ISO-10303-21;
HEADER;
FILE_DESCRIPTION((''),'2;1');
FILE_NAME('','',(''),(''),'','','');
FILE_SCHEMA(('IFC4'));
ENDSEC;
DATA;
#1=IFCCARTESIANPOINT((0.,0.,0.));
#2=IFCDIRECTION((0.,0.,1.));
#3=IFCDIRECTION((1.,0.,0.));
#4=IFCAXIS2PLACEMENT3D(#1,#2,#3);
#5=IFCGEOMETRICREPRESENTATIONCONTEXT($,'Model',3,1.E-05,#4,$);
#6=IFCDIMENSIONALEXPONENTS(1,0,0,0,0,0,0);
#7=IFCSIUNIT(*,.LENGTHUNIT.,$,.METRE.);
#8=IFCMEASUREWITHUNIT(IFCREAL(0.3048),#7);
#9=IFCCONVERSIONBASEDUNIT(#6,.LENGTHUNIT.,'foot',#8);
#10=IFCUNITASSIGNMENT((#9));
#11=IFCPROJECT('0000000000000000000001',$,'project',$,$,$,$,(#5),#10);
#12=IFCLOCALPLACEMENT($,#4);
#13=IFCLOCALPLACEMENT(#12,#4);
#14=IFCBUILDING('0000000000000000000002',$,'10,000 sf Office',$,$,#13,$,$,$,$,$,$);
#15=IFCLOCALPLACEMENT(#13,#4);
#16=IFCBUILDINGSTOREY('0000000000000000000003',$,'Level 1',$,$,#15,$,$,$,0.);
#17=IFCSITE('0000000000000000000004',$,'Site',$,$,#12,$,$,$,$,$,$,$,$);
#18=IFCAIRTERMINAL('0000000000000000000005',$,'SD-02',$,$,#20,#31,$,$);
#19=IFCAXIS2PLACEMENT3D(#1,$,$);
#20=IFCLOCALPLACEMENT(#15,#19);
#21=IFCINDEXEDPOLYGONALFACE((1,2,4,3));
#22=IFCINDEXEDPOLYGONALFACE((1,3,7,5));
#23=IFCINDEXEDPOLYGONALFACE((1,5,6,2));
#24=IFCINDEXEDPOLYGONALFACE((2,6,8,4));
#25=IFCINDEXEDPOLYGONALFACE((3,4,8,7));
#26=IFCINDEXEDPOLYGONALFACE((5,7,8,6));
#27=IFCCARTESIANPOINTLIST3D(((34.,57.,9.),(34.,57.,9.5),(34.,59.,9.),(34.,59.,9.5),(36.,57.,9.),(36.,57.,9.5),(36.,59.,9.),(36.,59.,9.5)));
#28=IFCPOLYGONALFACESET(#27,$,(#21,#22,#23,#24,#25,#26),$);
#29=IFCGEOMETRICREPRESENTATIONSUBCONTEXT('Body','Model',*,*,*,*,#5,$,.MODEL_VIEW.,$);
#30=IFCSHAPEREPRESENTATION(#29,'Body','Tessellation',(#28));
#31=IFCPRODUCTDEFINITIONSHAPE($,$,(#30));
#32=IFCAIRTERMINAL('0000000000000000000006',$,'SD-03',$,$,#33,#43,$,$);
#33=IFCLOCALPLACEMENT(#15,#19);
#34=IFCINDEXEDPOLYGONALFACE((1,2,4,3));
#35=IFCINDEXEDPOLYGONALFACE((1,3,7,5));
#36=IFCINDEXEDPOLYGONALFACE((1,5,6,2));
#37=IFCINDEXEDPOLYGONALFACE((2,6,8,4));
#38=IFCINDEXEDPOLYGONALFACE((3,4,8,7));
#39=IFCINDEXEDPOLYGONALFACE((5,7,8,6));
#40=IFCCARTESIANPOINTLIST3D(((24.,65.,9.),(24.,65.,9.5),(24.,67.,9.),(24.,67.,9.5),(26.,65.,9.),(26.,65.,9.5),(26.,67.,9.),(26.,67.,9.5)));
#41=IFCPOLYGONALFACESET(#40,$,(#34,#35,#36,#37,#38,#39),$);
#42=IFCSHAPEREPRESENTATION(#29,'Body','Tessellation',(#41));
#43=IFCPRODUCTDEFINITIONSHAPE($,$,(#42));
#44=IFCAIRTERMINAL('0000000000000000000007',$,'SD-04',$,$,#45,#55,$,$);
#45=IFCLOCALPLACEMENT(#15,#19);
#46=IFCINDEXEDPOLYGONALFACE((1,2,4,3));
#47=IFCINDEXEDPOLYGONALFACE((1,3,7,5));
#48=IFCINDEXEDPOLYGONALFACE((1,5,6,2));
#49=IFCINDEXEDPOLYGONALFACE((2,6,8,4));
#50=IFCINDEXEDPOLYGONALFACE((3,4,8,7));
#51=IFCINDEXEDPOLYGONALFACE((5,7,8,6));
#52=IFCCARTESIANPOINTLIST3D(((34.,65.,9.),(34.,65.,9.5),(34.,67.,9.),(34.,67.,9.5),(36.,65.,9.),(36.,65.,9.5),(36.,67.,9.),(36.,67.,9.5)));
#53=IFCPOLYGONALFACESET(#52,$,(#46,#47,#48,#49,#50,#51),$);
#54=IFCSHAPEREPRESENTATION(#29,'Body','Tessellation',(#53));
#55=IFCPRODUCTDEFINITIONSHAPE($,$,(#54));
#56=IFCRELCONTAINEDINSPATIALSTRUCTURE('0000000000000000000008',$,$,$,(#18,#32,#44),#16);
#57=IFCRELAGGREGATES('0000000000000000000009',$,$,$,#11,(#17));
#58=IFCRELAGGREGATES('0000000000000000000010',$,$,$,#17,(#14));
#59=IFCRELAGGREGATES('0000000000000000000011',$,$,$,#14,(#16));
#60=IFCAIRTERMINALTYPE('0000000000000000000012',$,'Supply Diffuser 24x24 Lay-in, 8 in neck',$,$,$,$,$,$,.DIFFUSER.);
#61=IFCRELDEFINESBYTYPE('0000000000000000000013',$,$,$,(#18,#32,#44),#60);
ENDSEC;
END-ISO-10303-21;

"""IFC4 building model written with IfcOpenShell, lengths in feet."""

from ifc_helpers import new_model, entity, si_unit, converted_unit, frame, origin_with_axes, place, context, subcontext, project, spatial, rectangle, extrude, type_object, element, save


model = new_model("IFC4")

# Units and contexts
model_context = context("Model", 3, precision=1e-05, world=origin_with_axes())
body_context = subcontext(model_context, "Body", "Model", "MODEL_VIEW")
ifc_project = project(units=[converted_unit("LENGTHUNIT", "foot", entity("IfcReal", 0.3048), si_unit("LENGTHUNIT", "METRE"), dimensions=[1, 0, 0, 0, 0, 0, 0])], contexts=[model_context])

# Site, building, storey
site_placement = place(None, origin_with_axes())
site = spatial("IfcSite", under=ifc_project, at=site_placement, Name="Site")
building_placement = place(site_placement, origin_with_axes())
building = spatial("IfcBuilding", under=site, at=building_placement, Name="10,000 sf Office")
storey_placement = place(building_placement, origin_with_axes())
storey = spatial("IfcBuildingStorey", under=building, at=storey_placement, Name="Level 1", Elevation=0.0)

# Air terminals
air_terminal_type = type_object("IfcAirTerminalType", Name="Supply Diffuser 24x24 Lay-in, 8 in neck", PredefinedType="DIFFUSER")
for number, where, z_axis, x_axis, name in (
    (1, (35.0, 58.0, 9.0), (0.0, 0.0, 1.0), (1.0, 0.0, 0.0), "SD-02"),
    (2, (25.0, 66.0, 9.0), (0.0, 0.0, 1.0), (1.0, 0.0, 0.0), "SD-03"),
    (3, (35.0, 66.0, 9.0), (0.0, 0.0, 1.0), (1.0, 0.0, 0.0), "SD-04"),
):
    element("IfcAirTerminal", number, at=place(storey_placement, frame(where, z_axis=z_axis, x_axis=x_axis)), inside=storey, type_object=air_terminal_type, Name=name, context=body_context, shape_type="SweptSolid", body=[
        extrude(rectangle(XDim=2.0, YDim=2.0), None, (0.0, 0.0, 1.0), 0.5),
    ])

save(model, "model.ifc")
